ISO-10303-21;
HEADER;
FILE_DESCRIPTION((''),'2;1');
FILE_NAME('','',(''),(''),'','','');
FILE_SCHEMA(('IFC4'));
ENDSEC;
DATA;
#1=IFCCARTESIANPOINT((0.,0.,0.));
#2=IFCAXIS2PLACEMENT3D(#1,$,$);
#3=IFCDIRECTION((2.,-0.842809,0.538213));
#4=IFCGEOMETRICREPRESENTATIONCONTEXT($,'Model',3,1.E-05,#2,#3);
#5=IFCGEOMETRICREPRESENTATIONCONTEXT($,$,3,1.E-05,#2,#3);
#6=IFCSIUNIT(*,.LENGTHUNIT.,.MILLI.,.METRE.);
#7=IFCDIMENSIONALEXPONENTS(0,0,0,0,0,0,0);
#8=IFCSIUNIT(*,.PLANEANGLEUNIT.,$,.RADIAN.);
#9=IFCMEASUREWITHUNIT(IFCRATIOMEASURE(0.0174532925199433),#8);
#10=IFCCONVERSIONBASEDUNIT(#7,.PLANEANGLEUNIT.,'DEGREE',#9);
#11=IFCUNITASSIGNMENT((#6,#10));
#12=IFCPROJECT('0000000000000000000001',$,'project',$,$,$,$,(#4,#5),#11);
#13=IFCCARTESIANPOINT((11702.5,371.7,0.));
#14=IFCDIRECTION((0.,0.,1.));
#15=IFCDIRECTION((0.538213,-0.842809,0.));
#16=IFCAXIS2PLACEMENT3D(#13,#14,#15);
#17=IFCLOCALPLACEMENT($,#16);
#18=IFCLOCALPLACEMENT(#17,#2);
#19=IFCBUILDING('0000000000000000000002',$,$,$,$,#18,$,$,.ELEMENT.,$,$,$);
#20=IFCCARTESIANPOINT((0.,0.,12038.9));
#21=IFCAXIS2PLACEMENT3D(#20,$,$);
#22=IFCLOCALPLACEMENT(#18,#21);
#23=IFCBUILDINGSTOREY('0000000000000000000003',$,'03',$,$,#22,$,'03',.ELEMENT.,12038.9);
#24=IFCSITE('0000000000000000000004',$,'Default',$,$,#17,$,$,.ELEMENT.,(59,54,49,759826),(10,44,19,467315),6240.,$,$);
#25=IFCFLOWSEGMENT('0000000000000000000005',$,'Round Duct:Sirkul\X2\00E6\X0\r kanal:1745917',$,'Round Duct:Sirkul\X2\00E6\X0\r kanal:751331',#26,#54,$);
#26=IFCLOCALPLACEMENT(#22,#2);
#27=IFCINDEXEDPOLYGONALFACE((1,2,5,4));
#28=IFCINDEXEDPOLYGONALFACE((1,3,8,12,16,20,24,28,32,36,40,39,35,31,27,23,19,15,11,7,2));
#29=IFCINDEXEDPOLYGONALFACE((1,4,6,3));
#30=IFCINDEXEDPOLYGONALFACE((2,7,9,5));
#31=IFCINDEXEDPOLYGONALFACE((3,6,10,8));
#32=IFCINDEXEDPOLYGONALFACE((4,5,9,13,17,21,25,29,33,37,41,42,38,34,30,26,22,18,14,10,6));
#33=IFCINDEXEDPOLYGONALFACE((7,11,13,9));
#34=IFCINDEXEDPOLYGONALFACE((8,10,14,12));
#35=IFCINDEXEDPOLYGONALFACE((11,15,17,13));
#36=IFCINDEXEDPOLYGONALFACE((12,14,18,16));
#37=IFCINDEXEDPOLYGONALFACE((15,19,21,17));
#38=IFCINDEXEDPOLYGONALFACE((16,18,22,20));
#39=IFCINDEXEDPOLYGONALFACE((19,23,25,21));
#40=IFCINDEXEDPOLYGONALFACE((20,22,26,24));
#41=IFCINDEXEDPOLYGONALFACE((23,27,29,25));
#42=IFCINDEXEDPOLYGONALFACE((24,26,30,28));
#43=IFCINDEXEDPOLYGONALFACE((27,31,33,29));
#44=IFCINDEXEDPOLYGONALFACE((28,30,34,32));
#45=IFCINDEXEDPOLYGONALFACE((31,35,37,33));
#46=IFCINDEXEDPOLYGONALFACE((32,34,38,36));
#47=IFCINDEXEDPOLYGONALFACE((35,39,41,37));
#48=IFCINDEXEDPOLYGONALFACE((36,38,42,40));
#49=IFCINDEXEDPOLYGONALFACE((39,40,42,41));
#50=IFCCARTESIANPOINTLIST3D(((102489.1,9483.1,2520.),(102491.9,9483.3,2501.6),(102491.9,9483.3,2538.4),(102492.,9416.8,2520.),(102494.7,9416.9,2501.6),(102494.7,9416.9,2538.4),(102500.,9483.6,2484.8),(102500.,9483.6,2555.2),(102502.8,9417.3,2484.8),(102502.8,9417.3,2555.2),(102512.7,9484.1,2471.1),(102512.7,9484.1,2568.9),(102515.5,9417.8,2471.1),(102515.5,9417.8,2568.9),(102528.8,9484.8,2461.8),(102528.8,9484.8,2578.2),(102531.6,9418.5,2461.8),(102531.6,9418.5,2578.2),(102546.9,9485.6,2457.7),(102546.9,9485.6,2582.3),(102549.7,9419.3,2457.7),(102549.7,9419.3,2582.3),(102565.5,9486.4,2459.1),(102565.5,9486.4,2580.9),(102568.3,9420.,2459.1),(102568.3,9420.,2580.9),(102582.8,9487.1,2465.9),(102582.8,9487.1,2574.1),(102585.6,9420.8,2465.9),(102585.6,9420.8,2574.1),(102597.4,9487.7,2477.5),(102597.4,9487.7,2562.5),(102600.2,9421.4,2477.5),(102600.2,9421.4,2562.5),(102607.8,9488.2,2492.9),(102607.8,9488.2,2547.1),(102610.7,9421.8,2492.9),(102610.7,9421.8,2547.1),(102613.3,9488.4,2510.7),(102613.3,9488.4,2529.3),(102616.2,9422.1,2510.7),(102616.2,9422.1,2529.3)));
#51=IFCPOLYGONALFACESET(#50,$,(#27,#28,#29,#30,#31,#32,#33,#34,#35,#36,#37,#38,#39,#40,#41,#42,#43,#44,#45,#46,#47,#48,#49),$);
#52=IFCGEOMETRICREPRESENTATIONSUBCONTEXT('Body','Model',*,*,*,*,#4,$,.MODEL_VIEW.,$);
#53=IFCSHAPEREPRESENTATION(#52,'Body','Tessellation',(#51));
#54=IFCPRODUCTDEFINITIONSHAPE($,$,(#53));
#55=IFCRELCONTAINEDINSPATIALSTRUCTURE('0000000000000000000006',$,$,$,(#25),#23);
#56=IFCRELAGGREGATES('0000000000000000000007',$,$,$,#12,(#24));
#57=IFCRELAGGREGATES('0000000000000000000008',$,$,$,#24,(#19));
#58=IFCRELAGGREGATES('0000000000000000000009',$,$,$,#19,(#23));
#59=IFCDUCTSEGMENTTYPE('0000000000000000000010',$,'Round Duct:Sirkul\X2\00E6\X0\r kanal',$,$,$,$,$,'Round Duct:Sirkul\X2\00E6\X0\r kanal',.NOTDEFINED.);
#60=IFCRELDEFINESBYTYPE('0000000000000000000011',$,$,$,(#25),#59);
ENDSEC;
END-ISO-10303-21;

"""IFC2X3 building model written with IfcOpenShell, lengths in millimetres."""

from ifc_helpers import new_model, entity, si_unit, converted_unit, direction, frame, frame_2d, origin, place, context, subcontext, project, spatial, circle, extrude, type_object, element, save


model = new_model("IFC2X3")

# Units and contexts
model_context = context("Model", 3, precision=1e-05, world=origin(), true_north=direction((2.0, -0.842809, 0.538213)))
context_of_model = context(None, 3, precision=1e-05, world=origin(), true_north=direction((2.0, -0.842809, 0.538213)))
body_context = subcontext(model_context, "Body", "Model", "MODEL_VIEW")
ifc_project = project(units=[si_unit("LENGTHUNIT", "METRE", prefix="MILLI"), converted_unit("PLANEANGLEUNIT", "DEGREE", entity("IfcRatioMeasure", 0.0174532925199433), si_unit("PLANEANGLEUNIT", "RADIAN"), dimensions=[0, 0, 0, 0, 0, 0, 0])], contexts=[model_context, context_of_model])

# Site, building, storey
site_placement = place(None, frame((11702.5, 371.7, 0.0), z_axis=(0.0, 0.0, 1.0), x_axis=(0.538213, -0.842809, 0.0)))
site = spatial("IfcSite", under=ifc_project, at=site_placement, Name="Default", CompositionType="ELEMENT", RefLatitude=(59, 54, 49, 759826), RefLongitude=(10, 44, 19, 467315), RefElevation=6240.0)
building_placement = place(site_placement, origin())
building = spatial("IfcBuilding", under=site, at=building_placement, CompositionType="ELEMENT")
storey_placement = place(building_placement, frame((0.0, 0.0, 12038.9)))
storey = spatial("IfcBuildingStorey", under=building, at=storey_placement, Name="03", LongName="03", CompositionType="ELEMENT", Elevation=12038.9)

# Flow segment
duct_segment_type = type_object("IfcDuctSegmentType", Name="Round Duct:Sirkulær kanal", ElementType="Round Duct:Sirkulær kanal", PredefinedType="NOTDEFINED")
flow_segment_1_placement = place(storey_placement, origin())
element("IfcFlowSegment", 1, at=flow_segment_1_placement, inside=storey, type_object=duct_segment_type, Name="Round Duct:Sirkulær kanal:1745917", ObjectType="Round Duct:Sirkulær kanal:751331", context=body_context, shape_type="SweptSolid", body=[
    extrude(circle(Radius=62.5, at=frame_2d((0.0, 0.0), x_axis=(1.0, 0.0))), frame((102554.4, 9419.5, 2520.0), z_axis=(-0.042537, 0.999095, 0.0), x_axis=(-0.999095, -0.042537, 0.0)), (0.0, 0.0, 1.0), 66.4),
])

save(model, "model.ifc")
